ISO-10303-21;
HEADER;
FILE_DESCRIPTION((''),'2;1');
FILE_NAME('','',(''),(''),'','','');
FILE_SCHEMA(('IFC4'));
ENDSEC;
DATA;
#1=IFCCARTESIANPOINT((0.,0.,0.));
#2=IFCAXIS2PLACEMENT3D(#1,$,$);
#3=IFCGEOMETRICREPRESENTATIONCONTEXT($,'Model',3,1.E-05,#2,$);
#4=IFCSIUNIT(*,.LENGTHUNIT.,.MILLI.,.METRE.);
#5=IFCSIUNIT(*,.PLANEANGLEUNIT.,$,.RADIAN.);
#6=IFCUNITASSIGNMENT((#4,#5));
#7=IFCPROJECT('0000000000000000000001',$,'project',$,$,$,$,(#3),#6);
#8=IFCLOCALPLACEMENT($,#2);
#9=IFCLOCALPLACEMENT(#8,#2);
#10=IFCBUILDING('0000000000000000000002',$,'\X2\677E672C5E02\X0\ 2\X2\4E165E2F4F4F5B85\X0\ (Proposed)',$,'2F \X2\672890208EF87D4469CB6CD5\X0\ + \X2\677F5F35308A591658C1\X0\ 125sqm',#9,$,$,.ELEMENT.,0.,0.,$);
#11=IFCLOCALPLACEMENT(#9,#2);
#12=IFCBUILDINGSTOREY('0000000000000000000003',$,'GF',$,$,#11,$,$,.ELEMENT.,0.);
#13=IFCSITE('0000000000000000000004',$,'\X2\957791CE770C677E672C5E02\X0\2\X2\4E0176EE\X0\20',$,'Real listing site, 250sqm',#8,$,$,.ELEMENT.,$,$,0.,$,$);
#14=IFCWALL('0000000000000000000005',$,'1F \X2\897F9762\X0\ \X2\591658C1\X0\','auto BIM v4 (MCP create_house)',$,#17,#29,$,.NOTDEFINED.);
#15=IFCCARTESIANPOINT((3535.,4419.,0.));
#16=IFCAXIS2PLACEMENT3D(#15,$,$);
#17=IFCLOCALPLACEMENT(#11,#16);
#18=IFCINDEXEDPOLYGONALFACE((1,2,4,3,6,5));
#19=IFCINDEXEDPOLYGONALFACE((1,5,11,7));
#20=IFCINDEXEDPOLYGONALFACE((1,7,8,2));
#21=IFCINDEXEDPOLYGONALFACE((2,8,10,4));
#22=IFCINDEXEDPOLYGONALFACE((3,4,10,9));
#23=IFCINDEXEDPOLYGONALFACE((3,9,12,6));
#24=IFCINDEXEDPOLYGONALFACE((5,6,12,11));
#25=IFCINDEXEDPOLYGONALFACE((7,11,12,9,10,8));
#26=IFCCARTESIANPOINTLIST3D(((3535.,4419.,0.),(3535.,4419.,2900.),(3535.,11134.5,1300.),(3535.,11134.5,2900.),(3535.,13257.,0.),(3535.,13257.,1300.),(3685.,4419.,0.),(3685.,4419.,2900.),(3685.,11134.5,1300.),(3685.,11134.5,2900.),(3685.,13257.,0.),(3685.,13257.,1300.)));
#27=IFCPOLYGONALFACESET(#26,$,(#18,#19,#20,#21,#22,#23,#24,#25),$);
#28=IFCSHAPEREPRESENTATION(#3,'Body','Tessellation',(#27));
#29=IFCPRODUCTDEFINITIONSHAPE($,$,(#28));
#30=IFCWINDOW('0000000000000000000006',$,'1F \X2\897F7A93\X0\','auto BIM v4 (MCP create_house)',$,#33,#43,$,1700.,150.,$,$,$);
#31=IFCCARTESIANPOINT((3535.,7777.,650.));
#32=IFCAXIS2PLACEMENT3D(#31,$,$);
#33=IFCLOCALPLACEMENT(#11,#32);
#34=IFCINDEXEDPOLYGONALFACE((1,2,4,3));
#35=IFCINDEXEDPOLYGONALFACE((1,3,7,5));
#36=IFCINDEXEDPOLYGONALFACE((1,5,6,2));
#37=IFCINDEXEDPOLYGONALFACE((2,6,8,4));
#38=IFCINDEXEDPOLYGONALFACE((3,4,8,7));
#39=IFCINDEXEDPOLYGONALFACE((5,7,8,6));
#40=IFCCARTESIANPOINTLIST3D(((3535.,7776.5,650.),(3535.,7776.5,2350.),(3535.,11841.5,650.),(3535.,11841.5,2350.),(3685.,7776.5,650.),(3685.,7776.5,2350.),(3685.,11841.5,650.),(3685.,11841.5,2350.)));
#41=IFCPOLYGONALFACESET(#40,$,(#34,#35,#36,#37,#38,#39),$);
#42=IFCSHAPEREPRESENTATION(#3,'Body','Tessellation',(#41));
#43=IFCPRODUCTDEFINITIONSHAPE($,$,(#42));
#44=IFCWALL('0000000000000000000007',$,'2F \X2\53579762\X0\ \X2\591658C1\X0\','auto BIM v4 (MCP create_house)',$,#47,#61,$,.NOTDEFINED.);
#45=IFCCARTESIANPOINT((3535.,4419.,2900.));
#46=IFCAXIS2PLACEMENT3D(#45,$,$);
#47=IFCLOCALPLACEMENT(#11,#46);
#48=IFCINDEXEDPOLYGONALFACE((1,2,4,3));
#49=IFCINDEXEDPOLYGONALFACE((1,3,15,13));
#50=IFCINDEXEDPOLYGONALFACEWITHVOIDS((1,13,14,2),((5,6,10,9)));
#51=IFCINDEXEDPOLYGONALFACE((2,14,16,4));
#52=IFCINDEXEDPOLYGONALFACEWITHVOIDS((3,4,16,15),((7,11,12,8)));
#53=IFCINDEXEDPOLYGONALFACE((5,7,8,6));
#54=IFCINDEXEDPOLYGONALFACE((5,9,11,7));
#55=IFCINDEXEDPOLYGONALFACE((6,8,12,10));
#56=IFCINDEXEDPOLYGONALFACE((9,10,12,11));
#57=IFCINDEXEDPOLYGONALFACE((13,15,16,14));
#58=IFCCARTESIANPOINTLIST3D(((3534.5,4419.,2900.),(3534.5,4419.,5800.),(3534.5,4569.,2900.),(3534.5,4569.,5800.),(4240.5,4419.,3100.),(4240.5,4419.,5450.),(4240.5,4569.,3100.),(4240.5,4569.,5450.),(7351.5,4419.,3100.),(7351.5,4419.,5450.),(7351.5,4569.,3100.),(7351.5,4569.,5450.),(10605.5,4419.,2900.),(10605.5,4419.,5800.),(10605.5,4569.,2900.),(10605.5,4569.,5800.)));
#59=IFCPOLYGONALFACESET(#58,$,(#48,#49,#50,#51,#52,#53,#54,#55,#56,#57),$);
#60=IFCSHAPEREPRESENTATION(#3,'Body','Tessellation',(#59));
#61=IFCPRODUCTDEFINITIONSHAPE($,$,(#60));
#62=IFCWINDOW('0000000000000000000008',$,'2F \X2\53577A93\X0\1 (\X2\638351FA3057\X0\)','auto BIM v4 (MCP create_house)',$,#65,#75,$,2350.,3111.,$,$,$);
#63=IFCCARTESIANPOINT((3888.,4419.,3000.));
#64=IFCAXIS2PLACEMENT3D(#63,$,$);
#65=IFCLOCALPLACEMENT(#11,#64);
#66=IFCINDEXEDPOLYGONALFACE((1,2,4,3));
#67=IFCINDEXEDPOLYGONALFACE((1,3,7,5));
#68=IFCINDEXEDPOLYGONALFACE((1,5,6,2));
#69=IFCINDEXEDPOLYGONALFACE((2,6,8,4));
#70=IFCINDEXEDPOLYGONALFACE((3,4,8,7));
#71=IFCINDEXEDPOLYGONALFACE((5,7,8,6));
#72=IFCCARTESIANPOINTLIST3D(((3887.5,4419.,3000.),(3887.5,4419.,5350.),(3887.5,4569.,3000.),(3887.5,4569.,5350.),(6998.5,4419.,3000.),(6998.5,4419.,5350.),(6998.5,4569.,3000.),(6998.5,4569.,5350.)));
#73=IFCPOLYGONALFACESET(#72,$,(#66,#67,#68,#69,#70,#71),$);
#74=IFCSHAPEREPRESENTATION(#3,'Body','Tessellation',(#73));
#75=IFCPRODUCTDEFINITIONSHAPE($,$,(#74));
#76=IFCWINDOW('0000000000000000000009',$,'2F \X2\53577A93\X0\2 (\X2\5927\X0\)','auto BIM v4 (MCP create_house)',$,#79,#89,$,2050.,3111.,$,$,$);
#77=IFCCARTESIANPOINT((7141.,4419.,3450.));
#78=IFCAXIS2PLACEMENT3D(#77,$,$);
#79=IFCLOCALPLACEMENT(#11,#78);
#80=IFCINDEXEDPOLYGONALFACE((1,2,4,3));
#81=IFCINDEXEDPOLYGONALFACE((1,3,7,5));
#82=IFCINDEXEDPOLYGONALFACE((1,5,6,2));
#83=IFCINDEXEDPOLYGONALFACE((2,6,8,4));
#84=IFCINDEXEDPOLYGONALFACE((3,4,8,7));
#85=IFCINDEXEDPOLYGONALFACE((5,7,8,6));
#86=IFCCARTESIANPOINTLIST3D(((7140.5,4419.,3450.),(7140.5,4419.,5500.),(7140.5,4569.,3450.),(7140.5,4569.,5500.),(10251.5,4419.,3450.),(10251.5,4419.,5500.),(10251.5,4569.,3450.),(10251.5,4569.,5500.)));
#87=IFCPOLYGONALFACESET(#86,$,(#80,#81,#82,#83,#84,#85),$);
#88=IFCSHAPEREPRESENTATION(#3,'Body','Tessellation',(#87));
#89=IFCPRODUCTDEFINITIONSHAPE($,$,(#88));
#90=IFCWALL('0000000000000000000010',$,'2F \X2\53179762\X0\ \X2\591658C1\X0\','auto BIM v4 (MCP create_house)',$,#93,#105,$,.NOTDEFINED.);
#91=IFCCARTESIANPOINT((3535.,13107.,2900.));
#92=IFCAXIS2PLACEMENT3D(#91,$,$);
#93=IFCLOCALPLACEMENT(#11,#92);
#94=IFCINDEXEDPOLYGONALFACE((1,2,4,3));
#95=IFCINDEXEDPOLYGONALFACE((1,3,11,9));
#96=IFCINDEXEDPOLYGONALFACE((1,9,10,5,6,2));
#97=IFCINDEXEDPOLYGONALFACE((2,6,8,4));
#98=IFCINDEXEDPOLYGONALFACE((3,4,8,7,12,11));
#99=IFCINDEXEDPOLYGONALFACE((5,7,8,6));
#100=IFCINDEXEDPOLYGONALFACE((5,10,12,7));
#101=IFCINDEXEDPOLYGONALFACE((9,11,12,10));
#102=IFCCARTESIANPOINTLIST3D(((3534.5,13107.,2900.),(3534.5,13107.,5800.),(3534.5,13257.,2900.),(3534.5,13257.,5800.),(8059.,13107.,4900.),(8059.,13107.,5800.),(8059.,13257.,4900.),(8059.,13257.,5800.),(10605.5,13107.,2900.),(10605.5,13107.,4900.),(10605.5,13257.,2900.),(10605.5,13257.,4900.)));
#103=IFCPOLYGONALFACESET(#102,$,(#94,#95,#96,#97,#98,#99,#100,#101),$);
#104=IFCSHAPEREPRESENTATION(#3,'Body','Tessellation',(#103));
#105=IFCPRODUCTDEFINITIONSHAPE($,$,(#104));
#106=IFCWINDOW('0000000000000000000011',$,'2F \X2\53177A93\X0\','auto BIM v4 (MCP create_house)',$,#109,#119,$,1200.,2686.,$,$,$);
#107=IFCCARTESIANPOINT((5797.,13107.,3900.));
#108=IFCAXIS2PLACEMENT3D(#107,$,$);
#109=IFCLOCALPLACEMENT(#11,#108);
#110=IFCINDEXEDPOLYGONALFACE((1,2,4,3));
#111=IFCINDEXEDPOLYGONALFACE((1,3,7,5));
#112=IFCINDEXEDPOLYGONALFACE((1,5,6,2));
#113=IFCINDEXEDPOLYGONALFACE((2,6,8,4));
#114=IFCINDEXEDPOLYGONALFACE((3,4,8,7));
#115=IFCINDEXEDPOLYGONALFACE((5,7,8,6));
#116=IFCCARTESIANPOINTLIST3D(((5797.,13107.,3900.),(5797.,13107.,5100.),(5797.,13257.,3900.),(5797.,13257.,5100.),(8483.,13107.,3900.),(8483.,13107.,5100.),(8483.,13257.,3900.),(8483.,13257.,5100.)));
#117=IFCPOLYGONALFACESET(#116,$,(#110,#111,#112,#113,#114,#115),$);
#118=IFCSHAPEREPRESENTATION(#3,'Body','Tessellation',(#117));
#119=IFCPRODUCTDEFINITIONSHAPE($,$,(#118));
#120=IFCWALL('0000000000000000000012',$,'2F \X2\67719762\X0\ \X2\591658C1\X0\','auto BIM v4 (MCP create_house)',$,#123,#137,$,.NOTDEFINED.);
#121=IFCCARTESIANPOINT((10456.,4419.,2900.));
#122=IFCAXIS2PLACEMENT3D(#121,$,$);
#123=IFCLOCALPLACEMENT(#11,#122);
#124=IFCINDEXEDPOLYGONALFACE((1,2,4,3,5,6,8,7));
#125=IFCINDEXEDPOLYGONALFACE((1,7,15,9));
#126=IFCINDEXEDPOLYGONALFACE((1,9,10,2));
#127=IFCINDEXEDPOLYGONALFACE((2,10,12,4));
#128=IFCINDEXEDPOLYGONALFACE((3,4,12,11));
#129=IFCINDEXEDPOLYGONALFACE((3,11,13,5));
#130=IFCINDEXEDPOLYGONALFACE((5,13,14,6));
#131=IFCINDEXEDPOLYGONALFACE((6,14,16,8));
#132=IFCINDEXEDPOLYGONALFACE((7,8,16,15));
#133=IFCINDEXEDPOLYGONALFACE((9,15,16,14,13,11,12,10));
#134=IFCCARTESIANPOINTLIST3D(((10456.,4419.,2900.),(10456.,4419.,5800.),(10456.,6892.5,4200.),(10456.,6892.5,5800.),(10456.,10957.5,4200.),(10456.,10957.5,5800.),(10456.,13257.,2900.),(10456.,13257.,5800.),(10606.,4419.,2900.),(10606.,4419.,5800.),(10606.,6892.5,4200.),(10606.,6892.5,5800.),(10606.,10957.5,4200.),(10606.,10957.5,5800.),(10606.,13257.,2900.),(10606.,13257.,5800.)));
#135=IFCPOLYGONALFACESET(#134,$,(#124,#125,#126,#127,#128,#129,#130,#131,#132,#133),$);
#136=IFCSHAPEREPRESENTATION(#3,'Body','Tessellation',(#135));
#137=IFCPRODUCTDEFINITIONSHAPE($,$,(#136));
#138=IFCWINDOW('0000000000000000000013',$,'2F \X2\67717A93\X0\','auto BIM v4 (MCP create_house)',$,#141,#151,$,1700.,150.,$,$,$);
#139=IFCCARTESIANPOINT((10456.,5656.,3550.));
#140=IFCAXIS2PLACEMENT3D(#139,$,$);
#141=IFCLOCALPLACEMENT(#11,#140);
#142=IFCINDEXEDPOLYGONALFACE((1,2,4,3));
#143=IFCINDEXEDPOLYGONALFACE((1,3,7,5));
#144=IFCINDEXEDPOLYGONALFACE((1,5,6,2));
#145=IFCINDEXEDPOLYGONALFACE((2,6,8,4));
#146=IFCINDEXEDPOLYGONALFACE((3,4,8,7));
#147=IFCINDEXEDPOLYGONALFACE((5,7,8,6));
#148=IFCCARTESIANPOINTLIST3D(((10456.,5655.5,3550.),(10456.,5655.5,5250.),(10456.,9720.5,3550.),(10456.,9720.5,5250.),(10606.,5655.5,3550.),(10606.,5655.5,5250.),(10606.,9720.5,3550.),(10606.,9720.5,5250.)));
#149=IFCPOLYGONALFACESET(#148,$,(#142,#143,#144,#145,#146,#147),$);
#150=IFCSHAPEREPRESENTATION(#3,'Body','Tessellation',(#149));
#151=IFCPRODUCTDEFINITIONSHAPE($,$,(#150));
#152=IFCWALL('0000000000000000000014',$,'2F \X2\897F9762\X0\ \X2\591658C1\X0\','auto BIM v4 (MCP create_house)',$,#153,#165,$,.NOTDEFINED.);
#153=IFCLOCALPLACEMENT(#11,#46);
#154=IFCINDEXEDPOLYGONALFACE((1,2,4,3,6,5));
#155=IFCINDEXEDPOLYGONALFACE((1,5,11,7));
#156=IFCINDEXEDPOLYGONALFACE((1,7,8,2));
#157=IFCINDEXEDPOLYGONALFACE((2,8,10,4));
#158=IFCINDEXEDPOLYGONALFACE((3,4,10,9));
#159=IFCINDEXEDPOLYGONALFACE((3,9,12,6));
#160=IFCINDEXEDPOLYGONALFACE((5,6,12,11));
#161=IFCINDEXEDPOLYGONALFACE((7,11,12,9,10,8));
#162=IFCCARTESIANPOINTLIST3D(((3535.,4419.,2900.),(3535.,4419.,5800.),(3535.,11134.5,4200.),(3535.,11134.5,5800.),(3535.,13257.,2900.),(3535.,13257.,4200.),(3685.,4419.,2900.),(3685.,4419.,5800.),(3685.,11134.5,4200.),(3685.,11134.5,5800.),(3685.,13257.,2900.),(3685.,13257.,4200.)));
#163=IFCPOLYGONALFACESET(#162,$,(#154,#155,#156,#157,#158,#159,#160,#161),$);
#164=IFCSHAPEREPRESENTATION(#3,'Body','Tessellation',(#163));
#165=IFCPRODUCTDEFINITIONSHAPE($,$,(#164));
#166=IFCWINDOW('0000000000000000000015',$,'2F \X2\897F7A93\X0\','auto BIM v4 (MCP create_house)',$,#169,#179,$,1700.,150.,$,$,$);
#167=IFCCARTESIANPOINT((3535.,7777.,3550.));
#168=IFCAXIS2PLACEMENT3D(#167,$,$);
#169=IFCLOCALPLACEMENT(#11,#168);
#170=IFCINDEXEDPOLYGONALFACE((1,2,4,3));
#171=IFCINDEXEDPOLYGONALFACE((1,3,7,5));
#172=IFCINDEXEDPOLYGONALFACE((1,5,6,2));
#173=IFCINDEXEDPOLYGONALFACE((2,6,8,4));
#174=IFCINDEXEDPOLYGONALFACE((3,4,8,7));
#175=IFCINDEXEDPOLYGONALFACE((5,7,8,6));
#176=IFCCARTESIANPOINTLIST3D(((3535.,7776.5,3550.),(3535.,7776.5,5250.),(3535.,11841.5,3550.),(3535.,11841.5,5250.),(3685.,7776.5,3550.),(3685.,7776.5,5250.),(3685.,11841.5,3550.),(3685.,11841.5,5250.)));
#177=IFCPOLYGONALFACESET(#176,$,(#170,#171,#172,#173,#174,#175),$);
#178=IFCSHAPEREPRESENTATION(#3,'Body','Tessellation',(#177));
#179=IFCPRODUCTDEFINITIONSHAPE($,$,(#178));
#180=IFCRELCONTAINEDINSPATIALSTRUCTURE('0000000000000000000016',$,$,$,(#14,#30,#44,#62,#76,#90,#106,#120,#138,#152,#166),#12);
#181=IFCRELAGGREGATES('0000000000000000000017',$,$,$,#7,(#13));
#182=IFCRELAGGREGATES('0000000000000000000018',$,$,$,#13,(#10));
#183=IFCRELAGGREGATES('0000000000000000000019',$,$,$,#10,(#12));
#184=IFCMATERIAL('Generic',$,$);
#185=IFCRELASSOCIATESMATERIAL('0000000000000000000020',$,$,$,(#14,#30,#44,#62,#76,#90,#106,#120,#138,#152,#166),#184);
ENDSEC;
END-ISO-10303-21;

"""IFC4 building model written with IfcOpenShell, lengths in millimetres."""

from ifc_helpers import new_model, si_unit, frame, frame_2d, origin, place, context, project, spatial, rectangle, extrude, material, element, fill, save


model = new_model("IFC4")

# Units and contexts
model_context = context("Model", 3, precision=1e-05, world=origin())
ifc_project = project(units=[si_unit("LENGTHUNIT", "METRE", prefix="MILLI"), si_unit("PLANEANGLEUNIT", "RADIAN")], contexts=[model_context])

# Site, building, storey
site_placement = place(None, origin())
site = spatial("IfcSite", under=ifc_project, at=site_placement, Name="長野県松本市2丁目20", ObjectType="Real listing site, 250sqm", CompositionType="ELEMENT", RefElevation=0.0)
building_placement = place(site_placement, origin())
building = spatial("IfcBuilding", under=site, at=building_placement, Name="松本市 2世帯住宅 (Proposed)", ObjectType="2F 木造軸組構法 + 板張り外壁 125sqm", CompositionType="ELEMENT", ElevationOfRefHeight=0.0, ElevationOfTerrain=0.0)
storey_placement = place(building_placement, origin())
storey = spatial("IfcBuildingStorey", under=building, at=storey_placement, Name="GF", CompositionType="ELEMENT", Elevation=0.0)

# Shared definitions
ifc_material = material(Name="Generic")

# Wall, opening, window
wall_1_placement = place(storey_placement, frame((3535.0, 4419.0, 0.0)))
wall_1 = element("IfcWall", 1, at=wall_1_placement, inside=storey, material=ifc_material, Name="1F 西面 外壁", Description="auto BIM v4 (MCP create_house)", PredefinedType="NOTDEFINED", context=model_context, shape_type="SweptSolid", body=[
    extrude(rectangle(XDim=150.0, YDim=8838.0, at=frame_2d((75.0, 4419.0))), frame((3535.0, 4419.0, 0.0)), (0.0, 0.0, 1.0), 2900.0),
])
opening_1_placement = place(storey_placement, frame((3535.0, 7777.0, 650.0)))
opening_1 = element("IfcOpeningElement", 2, at=opening_1_placement, cuts=wall_1, PredefinedType="NOTDEFINED", context=model_context, shape_type="SweptSolid", body=[
    extrude(rectangle(XDim=150.0, YDim=4065.0, at=frame_2d((75.0, 2032.0))), frame((3535.0, 7777.0, 650.0)), (0.0, 0.0, 1.0), 1700.0),
])
window_1_placement = place(storey_placement, frame((3535.0, 7777.0, 650.0)))
window_1 = element("IfcWindow", 3, at=window_1_placement, inside=storey, material=ifc_material, Name="1F 西窓", Description="auto BIM v4 (MCP create_house)", OverallHeight=1700.0, OverallWidth=150.0, context=model_context, shape_type="SweptSolid", body=[
    extrude(rectangle(XDim=150.0, YDim=4065.0, at=frame_2d((75.0, 2032.0))), frame((3535.0, 7777.0, 650.0)), (0.0, 0.0, 1.0), 1700.0),
])
fill(opening_1, window_1)

# Wall, openings, windows
wall_2_placement = place(storey_placement, frame((3535.0, 4419.0, 2900.0)))
wall_2 = element("IfcWall", 4, at=wall_2_placement, inside=storey, material=ifc_material, Name="2F 南面 外壁", Description="auto BIM v4 (MCP create_house)", PredefinedType="NOTDEFINED", context=model_context, shape_type="SweptSolid", body=[
    extrude(rectangle(XDim=7071.0, YDim=150.0, at=frame_2d((3535.0, 75.0))), frame((3535.0, 4419.0, 2900.0)), (0.0, 0.0, 1.0), 2900.0),
])
opening_2_placement = place(storey_placement, frame((3888.0, 4419.0, 3000.0)))
opening_2 = element("IfcOpeningElement", 5, at=opening_2_placement, cuts=wall_2, PredefinedType="NOTDEFINED", context=model_context, shape_type="SweptSolid", body=[
    extrude(rectangle(XDim=3111.0, YDim=150.0, at=frame_2d((1555.0, 75.0))), frame((3888.0, 4419.0, 3000.0)), (0.0, 0.0, 1.0), 2350.0),
])
opening_3_placement = place(storey_placement, frame((7141.0, 4419.0, 3450.0)))
opening_3 = element("IfcOpeningElement", 6, at=opening_3_placement, cuts=wall_2, PredefinedType="NOTDEFINED", context=model_context, shape_type="SweptSolid", body=[
    extrude(rectangle(XDim=3111.0, YDim=150.0, at=frame_2d((1555.0, 75.0))), frame((7141.0, 4419.0, 3450.0)), (0.0, 0.0, 1.0), 2050.0),
])
window_2_placement = place(storey_placement, frame((3888.0, 4419.0, 3000.0)))
window_2 = element("IfcWindow", 7, at=window_2_placement, inside=storey, material=ifc_material, Name="2F 南窓1 (掃出し)", Description="auto BIM v4 (MCP create_house)", OverallHeight=2350.0, OverallWidth=3111.0, context=model_context, shape_type="SweptSolid", body=[
    extrude(rectangle(XDim=3111.0, YDim=150.0, at=frame_2d((1555.0, 75.0))), frame((3888.0, 4419.0, 3000.0)), (0.0, 0.0, 1.0), 2350.0),
])
fill(opening_2, window_2)
window_3_placement = place(storey_placement, frame((7141.0, 4419.0, 3450.0)))
window_3 = element("IfcWindow", 8, at=window_3_placement, inside=storey, material=ifc_material, Name="2F 南窓2 (大)", Description="auto BIM v4 (MCP create_house)", OverallHeight=2050.0, OverallWidth=3111.0, context=model_context, shape_type="SweptSolid", body=[
    extrude(rectangle(XDim=3111.0, YDim=150.0, at=frame_2d((1555.0, 75.0))), frame((7141.0, 4419.0, 3450.0)), (0.0, 0.0, 1.0), 2050.0),
])
fill(opening_3, window_3)

# Walls, openings, windows
wall_3_placement = place(storey_placement, frame((3535.0, 13107.0, 2900.0)))
wall_3 = element("IfcWall", 9, at=wall_3_placement, inside=storey, material=ifc_material, Name="2F 北面 外壁", Description="auto BIM v4 (MCP create_house)", PredefinedType="NOTDEFINED", context=model_context, shape_type="SweptSolid", body=[
    extrude(rectangle(XDim=7071.0, YDim=150.0, at=frame_2d((3535.0, 75.0))), frame((3535.0, 13107.0, 2900.0)), (0.0, 0.0, 1.0), 2900.0),
])
opening_4_placement = place(storey_placement, frame((5797.0, 13107.0, 3900.0)))
opening_4 = element("IfcOpeningElement", 10, at=opening_4_placement, cuts=wall_3, PredefinedType="NOTDEFINED", context=model_context, shape_type="SweptSolid", body=[
    extrude(rectangle(XDim=2686.0, YDim=150.0, at=frame_2d((1343.0, 75.0))), frame((5797.0, 13107.0, 3900.0)), (0.0, 0.0, 1.0), 1200.0),
])
window_4_placement = place(storey_placement, frame((5797.0, 13107.0, 3900.0)))
window_4 = element("IfcWindow", 11, at=window_4_placement, inside=storey, material=ifc_material, Name="2F 北窓", Description="auto BIM v4 (MCP create_house)", OverallHeight=1200.0, OverallWidth=2686.0, context=model_context, shape_type="SweptSolid", body=[
    extrude(rectangle(XDim=2686.0, YDim=150.0, at=frame_2d((1343.0, 75.0))), frame((5797.0, 13107.0, 3900.0)), (0.0, 0.0, 1.0), 1200.0),
])
fill(opening_4, window_4)
wall_4_placement = place(storey_placement, frame((10456.0, 4419.0, 2900.0)))
wall_4 = element("IfcWall", 12, at=wall_4_placement, inside=storey, material=ifc_material, Name="2F 東面 外壁", Description="auto BIM v4 (MCP create_house)", PredefinedType="NOTDEFINED", context=model_context, shape_type="SweptSolid", body=[
    extrude(rectangle(XDim=150.0, YDim=8838.0, at=frame_2d((75.0, 4419.0))), frame((10456.0, 4419.0, 2900.0)), (0.0, 0.0, 1.0), 2900.0),
])
opening_5_placement = place(storey_placement, frame((10456.0, 5656.0, 3550.0)))
opening_5 = element("IfcOpeningElement", 13, at=opening_5_placement, cuts=wall_4, PredefinedType="NOTDEFINED", context=model_context, shape_type="SweptSolid", body=[
    extrude(rectangle(XDim=150.0, YDim=4065.0, at=frame_2d((75.0, 2032.0))), frame((10456.0, 5656.0, 3550.0)), (0.0, 0.0, 1.0), 1700.0),
])
window_5_placement = place(storey_placement, frame((10456.0, 5656.0, 3550.0)))
window_5 = element("IfcWindow", 14, at=window_5_placement, inside=storey, material=ifc_material, Name="2F 東窓", Description="auto BIM v4 (MCP create_house)", OverallHeight=1700.0, OverallWidth=150.0, context=model_context, shape_type="SweptSolid", body=[
    extrude(rectangle(XDim=150.0, YDim=4065.0, at=frame_2d((75.0, 2032.0))), frame((10456.0, 5656.0, 3550.0)), (0.0, 0.0, 1.0), 1700.0),
])
fill(opening_5, window_5)
wall_5_placement = place(storey_placement, frame((3535.0, 4419.0, 2900.0)))
wall_5 = element("IfcWall", 15, at=wall_5_placement, inside=storey, material=ifc_material, Name="2F 西面 外壁", Description="auto BIM v4 (MCP create_house)", PredefinedType="NOTDEFINED", context=model_context, shape_type="SweptSolid", body=[
    extrude(rectangle(XDim=150.0, YDim=8838.0, at=frame_2d((75.0, 4419.0))), frame((3535.0, 4419.0, 2900.0)), (0.0, 0.0, 1.0), 2900.0),
])
opening_6_placement = place(storey_placement, frame((3535.0, 7777.0, 3550.0)))
opening_6 = element("IfcOpeningElement", 16, at=opening_6_placement, cuts=wall_5, PredefinedType="NOTDEFINED", context=model_context, shape_type="SweptSolid", body=[
    extrude(rectangle(XDim=150.0, YDim=4065.0, at=frame_2d((75.0, 2032.0))), frame((3535.0, 7777.0, 3550.0)), (0.0, 0.0, 1.0), 1700.0),
])
window_6_placement = place(storey_placement, frame((3535.0, 7777.0, 3550.0)))
window_6 = element("IfcWindow", 17, at=window_6_placement, inside=storey, material=ifc_material, Name="2F 西窓", Description="auto BIM v4 (MCP create_house)", OverallHeight=1700.0, OverallWidth=150.0, context=model_context, shape_type="SweptSolid", body=[
    extrude(rectangle(XDim=150.0, YDim=4065.0, at=frame_2d((75.0, 2032.0))), frame((3535.0, 7777.0, 3550.0)), (0.0, 0.0, 1.0), 1700.0),
])
fill(opening_6, window_6)

save(model, "model.ifc")
